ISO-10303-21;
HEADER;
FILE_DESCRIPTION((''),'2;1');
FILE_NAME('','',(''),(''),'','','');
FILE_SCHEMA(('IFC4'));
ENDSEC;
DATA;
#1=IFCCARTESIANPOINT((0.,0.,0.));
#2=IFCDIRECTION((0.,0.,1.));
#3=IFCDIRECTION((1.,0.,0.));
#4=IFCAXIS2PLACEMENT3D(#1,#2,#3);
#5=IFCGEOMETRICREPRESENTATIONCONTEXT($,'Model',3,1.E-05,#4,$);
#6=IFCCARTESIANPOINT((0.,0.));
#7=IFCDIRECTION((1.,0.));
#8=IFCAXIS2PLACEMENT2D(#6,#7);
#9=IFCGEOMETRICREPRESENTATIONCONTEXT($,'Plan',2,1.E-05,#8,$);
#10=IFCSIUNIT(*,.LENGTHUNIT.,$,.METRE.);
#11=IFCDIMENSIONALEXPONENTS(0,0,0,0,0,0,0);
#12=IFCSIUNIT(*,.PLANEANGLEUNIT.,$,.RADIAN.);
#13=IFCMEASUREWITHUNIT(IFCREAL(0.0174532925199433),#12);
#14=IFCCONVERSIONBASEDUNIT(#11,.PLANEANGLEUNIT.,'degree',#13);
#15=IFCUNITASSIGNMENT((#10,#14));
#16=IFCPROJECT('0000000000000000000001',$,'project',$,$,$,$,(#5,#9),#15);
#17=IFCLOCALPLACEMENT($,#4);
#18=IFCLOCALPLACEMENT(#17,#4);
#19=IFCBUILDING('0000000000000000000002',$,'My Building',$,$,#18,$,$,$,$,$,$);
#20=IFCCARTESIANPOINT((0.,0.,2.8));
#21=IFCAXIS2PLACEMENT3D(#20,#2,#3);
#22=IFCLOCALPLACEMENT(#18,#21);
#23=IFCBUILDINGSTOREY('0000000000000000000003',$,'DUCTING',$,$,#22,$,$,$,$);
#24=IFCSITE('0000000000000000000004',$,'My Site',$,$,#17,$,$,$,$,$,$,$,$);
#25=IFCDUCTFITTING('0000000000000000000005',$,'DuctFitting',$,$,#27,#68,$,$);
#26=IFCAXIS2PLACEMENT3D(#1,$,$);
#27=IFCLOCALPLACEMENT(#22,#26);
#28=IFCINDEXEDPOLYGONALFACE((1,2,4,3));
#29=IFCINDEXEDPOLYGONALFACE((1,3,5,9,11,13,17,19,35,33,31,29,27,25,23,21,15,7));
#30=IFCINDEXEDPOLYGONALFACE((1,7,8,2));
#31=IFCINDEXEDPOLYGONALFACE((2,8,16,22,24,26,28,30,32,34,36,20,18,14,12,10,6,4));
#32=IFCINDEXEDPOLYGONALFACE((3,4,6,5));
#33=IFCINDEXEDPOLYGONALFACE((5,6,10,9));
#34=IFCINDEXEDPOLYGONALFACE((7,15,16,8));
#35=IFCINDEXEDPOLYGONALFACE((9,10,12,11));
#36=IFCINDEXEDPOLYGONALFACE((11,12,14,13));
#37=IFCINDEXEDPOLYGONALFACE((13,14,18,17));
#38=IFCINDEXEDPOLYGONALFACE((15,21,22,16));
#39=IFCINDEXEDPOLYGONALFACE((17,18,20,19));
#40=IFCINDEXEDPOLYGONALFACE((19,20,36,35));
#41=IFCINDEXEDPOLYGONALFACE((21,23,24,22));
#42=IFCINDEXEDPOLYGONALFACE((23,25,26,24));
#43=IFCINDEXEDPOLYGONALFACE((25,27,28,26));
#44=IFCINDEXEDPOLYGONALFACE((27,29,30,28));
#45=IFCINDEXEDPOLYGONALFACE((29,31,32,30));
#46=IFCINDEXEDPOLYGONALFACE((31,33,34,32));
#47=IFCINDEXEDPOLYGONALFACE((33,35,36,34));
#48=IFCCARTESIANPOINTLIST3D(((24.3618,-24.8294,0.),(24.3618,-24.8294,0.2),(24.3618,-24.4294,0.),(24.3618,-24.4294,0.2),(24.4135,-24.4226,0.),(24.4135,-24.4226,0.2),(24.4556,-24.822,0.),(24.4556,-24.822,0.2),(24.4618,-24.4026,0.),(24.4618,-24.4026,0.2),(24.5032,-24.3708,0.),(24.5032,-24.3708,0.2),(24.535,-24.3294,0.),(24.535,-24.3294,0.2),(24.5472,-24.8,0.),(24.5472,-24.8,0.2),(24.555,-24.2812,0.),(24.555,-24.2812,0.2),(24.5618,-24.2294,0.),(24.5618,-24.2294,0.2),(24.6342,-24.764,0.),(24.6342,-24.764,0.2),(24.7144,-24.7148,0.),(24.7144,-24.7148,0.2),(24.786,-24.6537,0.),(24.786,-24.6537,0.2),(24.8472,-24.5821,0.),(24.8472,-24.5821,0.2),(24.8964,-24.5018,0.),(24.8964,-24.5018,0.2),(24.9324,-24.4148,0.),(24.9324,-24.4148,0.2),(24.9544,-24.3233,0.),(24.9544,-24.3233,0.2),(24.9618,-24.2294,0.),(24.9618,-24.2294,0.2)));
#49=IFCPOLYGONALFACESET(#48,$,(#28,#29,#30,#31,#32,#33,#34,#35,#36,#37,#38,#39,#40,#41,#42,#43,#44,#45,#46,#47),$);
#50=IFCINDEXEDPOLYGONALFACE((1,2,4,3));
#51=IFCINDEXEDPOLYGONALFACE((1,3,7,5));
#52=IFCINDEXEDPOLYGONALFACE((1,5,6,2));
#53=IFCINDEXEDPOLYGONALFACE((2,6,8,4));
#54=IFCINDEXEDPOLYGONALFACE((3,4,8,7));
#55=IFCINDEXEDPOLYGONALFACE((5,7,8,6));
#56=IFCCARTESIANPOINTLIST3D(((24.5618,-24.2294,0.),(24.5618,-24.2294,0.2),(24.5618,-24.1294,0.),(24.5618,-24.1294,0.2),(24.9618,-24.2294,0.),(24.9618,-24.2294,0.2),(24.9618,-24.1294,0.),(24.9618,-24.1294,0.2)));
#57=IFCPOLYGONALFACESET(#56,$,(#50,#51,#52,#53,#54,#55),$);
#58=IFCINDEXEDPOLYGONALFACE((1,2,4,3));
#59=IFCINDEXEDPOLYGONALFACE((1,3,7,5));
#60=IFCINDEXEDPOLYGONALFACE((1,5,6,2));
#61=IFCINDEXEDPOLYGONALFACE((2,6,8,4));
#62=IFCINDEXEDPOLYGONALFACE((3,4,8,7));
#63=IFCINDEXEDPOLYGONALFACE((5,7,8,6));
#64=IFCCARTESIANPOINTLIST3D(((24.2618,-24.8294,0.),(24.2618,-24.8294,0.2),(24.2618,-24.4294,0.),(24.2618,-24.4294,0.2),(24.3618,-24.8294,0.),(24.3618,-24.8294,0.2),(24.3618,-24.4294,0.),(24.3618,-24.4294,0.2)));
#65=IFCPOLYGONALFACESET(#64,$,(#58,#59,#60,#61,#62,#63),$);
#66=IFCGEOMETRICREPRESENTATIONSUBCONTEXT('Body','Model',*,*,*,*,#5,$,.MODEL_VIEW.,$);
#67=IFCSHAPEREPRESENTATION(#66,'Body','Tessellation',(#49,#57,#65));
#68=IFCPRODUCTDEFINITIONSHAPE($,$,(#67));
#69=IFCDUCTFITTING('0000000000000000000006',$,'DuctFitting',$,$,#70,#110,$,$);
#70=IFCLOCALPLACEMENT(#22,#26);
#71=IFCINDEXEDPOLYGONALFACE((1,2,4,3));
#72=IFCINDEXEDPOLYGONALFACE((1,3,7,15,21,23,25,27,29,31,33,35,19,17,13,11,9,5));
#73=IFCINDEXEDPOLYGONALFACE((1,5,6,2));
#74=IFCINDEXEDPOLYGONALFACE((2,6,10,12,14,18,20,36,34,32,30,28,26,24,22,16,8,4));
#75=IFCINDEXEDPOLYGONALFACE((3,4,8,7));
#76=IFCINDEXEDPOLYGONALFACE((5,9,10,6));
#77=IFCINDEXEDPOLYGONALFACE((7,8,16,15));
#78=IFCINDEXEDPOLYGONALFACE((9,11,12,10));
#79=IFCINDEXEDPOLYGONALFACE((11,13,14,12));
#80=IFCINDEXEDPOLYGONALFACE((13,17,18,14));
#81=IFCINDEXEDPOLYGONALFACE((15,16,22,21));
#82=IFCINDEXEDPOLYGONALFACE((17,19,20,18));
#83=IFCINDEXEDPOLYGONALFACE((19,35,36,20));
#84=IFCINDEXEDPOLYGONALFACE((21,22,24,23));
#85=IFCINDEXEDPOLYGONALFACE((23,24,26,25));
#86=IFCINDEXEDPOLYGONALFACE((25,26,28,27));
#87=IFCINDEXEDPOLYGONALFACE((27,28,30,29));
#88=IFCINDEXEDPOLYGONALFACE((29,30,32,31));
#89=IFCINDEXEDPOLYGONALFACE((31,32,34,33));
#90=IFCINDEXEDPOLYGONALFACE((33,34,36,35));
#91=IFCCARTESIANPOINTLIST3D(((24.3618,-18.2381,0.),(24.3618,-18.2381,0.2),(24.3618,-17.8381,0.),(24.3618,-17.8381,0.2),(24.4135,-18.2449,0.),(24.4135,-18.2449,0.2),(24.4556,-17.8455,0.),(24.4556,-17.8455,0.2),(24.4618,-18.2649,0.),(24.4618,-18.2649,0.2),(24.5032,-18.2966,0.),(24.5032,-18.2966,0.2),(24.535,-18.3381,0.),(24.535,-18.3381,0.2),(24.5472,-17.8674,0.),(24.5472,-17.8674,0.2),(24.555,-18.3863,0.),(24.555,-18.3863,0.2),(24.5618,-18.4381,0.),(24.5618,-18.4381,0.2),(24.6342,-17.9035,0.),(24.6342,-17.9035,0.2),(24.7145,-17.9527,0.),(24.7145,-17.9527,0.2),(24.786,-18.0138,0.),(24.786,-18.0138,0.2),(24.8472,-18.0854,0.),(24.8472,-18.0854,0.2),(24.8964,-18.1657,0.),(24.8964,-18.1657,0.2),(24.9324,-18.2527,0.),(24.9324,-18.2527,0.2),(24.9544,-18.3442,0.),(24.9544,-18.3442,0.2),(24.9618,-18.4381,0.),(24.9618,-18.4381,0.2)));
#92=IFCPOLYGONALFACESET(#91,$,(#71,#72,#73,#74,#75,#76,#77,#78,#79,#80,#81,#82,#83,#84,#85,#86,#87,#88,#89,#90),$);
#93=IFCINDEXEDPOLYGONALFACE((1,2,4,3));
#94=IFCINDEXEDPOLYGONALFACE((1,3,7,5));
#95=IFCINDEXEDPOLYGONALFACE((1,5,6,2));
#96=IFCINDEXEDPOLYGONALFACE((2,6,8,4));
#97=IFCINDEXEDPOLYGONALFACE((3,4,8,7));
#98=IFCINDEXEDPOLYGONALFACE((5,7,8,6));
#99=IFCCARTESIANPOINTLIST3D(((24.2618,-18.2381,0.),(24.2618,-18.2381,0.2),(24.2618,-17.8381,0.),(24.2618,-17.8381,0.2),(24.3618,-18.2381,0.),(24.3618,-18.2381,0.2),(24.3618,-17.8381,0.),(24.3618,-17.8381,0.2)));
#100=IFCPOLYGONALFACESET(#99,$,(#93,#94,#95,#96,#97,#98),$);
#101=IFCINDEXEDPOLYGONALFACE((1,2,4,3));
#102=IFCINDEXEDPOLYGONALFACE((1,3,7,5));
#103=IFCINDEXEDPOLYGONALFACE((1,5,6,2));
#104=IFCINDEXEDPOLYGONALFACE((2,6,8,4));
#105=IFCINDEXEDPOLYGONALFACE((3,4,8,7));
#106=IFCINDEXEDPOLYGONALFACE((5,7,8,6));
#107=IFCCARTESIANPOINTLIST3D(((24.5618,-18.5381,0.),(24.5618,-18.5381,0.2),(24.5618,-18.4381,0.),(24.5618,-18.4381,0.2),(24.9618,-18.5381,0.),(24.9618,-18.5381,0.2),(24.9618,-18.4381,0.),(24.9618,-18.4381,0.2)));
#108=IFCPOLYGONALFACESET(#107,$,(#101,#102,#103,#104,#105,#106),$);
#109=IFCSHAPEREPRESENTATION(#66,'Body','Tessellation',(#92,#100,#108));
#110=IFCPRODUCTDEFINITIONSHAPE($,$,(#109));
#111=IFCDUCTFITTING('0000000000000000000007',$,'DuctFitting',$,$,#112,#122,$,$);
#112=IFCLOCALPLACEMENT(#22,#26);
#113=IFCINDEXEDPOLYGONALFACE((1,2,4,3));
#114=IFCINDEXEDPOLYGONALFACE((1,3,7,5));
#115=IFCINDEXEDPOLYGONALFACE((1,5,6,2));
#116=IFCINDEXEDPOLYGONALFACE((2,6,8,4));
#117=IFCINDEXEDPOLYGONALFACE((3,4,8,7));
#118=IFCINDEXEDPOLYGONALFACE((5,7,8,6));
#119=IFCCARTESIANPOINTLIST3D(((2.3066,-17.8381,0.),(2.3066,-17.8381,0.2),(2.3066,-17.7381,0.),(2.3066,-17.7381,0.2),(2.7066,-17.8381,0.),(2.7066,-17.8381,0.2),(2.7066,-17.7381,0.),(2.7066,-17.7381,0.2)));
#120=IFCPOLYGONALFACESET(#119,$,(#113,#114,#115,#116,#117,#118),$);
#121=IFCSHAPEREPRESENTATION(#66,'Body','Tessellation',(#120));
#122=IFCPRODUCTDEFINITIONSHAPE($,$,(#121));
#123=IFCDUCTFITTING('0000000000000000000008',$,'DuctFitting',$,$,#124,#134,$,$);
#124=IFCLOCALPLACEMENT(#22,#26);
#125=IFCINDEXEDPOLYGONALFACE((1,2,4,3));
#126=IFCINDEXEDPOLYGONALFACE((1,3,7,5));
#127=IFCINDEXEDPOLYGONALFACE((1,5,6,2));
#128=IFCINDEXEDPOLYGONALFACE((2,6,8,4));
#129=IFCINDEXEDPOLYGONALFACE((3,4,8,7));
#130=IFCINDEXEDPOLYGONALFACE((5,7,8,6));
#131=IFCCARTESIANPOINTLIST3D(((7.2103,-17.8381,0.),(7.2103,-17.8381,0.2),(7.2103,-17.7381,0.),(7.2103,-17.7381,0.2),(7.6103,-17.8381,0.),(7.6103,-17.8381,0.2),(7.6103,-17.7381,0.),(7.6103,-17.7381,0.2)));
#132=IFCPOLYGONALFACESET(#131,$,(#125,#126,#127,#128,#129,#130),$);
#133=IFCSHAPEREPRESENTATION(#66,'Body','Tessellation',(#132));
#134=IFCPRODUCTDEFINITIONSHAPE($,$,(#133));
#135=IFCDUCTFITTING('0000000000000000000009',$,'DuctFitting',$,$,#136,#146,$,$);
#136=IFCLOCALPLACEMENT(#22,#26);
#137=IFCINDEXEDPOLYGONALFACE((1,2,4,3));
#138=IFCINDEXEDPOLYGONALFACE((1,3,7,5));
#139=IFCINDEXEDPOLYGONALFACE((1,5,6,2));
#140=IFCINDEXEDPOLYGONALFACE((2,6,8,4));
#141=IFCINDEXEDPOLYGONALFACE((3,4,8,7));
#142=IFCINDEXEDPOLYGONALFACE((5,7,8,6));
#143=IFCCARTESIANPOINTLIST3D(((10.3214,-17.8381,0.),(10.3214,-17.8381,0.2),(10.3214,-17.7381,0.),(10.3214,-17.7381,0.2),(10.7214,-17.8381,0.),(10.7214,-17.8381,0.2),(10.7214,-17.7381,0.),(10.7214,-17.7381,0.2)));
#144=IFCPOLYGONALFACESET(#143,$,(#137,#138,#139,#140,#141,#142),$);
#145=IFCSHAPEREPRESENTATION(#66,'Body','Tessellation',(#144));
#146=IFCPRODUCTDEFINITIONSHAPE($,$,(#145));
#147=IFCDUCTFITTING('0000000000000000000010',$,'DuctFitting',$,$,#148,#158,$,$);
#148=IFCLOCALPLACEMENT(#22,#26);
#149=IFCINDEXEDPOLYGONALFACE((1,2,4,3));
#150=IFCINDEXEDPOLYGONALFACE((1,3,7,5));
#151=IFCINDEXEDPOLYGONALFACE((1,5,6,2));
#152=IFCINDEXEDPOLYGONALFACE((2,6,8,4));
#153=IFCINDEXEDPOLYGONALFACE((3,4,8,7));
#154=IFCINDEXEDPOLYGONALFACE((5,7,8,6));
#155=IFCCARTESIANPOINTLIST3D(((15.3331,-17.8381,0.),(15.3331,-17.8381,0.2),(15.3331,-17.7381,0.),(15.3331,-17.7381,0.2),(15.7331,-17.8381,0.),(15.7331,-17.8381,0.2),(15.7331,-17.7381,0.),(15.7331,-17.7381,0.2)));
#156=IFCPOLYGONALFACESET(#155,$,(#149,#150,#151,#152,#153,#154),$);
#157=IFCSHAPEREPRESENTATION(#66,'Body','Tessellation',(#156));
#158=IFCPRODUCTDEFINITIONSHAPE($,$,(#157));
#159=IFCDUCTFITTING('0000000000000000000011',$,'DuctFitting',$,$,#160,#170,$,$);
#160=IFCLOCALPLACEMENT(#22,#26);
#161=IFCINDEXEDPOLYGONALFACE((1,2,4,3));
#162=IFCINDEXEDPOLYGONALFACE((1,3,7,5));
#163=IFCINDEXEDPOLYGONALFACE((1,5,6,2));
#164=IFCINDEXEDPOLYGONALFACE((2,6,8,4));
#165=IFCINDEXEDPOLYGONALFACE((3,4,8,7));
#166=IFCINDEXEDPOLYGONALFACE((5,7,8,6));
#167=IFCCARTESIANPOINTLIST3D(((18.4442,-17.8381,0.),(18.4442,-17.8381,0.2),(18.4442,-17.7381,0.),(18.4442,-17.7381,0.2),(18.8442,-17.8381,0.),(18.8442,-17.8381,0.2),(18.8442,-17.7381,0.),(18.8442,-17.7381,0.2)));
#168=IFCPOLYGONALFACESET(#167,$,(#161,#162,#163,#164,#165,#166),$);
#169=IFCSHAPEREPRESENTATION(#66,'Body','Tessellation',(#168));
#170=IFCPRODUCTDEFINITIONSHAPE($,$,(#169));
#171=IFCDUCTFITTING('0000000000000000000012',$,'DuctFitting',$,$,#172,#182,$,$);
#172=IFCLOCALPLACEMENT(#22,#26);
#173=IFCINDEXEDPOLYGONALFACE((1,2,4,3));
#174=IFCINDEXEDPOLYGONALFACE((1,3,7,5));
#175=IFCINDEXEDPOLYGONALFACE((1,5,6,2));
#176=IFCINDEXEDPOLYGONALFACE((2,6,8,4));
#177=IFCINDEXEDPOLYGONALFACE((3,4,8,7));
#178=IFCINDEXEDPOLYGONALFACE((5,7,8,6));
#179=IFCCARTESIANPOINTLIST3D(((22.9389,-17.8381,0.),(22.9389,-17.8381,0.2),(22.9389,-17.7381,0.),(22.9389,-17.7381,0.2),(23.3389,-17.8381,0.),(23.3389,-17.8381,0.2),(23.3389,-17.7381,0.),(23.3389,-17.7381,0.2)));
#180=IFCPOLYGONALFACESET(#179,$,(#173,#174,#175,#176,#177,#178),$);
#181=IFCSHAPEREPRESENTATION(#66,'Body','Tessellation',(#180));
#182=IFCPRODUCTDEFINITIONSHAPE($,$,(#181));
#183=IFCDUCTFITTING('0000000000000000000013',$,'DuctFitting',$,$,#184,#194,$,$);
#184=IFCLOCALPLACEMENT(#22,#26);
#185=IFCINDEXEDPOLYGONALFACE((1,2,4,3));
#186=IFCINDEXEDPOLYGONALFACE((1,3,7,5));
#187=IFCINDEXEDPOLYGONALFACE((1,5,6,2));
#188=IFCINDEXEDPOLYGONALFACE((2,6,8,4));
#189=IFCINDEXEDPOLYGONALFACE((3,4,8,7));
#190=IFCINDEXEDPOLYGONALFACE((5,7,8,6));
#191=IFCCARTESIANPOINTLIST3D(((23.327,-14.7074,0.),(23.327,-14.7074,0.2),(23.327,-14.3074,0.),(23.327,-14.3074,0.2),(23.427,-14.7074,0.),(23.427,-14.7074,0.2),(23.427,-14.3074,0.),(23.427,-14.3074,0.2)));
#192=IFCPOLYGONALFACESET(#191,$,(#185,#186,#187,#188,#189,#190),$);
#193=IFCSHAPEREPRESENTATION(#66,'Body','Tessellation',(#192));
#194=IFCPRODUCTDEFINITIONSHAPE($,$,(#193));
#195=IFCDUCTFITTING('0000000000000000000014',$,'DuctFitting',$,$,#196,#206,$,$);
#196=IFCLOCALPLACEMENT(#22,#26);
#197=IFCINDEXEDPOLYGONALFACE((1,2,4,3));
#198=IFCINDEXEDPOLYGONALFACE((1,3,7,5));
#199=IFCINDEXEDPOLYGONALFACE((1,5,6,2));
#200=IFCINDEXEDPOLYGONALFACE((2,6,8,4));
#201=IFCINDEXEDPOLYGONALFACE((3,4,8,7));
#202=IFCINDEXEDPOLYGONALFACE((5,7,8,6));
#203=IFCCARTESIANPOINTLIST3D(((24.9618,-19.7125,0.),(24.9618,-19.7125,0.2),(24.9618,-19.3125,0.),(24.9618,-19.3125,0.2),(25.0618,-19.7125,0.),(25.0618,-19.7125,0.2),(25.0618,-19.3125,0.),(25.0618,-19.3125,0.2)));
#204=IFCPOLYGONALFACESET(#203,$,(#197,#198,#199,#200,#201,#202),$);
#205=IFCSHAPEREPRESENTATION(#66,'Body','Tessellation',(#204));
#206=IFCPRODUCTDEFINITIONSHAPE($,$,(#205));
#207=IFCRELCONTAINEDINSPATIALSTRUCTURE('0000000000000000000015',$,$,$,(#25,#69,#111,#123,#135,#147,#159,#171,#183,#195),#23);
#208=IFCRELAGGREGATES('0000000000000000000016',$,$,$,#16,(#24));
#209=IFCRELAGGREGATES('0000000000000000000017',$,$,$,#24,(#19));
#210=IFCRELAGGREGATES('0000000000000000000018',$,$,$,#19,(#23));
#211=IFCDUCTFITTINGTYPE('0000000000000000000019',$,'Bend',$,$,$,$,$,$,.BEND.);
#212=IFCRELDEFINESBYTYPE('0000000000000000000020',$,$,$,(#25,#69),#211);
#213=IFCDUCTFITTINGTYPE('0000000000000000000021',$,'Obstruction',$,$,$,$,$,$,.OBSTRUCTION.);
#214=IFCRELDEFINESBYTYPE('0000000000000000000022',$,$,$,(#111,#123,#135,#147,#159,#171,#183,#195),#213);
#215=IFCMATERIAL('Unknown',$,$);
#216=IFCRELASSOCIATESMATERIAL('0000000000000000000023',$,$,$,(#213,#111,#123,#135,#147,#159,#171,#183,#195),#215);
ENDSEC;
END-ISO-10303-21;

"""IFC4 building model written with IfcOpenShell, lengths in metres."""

from ifc_helpers import new_model, entity, si_unit, converted_unit, frame, origin_with_axes, origin_2d_with_axis, place, context, subcontext, project, spatial, line, arc, indexed_curve, rectangle, outline, extrude, source, transform, mapped, material, material_profile, profile_set, profile_usage, type_object, type_shapes, element, save


model = new_model("IFC4")

# Units and contexts
model_context = context("Model", 3, precision=1e-05, world=origin_with_axes())
plan_context = context("Plan", 2, precision=1e-05, world=origin_2d_with_axis())
body_context = subcontext(model_context, "Body", "Model", "MODEL_VIEW")
ifc_project = project(units=[si_unit("LENGTHUNIT", "METRE"), converted_unit("PLANEANGLEUNIT", "degree", entity("IfcReal", 0.0174532925199433), si_unit("PLANEANGLEUNIT", "RADIAN"), dimensions=[0, 0, 0, 0, 0, 0, 0])], contexts=[model_context, plan_context])

# Site, building, storey
site_placement = place(None, origin_with_axes())
site = spatial("IfcSite", under=ifc_project, at=site_placement, Name="My Site")
building_placement = place(site_placement, origin_with_axes())
building = spatial("IfcBuilding", under=site, at=building_placement, Name="My Building")
storey_placement = place(building_placement, frame((0.0, 0.0, 2.8), z_axis=(0.0, 0.0, 1.0), x_axis=(1.0, 0.0, 0.0)))
storey = spatial("IfcBuildingStorey", under=building, at=storey_placement, Name="DUCTING")

# Shared definitions
ifc_material = material(Name="Unknown")

# Duct fittings
duct_fitting_type_1 = type_object("IfcDuctFittingType", Name="Bend", PredefinedType="BEND")
shared_shape = source(origin_with_axes(), body_context, "Body", "SweptSolid", [
    extrude(outline(indexed_curve([(-0.2, 0.0), (-0.2586, -0.1414), (-0.4, -0.2), (-0.4, -0.6), (0.0243, -0.4243), (0.2, 0.0)], segments=[arc(1, 2, 3), line(3, 4), arc(4, 5, 6), line(6, 1)])), frame((0.0, -0.1, -0.1), z_axis=(0.0, -1.0, 0.0), x_axis=(1.0, 0.0, 0.0)), (0.0, 0.0, -1.0), 0.2),
    extrude(rectangle(XDim=0.4, YDim=0.2), origin_with_axes(), (0.0, 0.0, -1.0), 0.1),
    extrude(rectangle(XDim=0.4, YDim=0.2), frame((-0.4, 0.0, -0.5), z_axis=(-1.0, 0.0, 0.0), x_axis=(0.0, 0.0, -1.0)), (0.0, 0.0, 1.0), 0.1),
])
type_shapes(duct_fitting_type_1, [shared_shape])
for number, where, z_axis, x_axis, name in (
    (1, (24.7618, -24.1294, 0.1), (0.0, 1.0, 0.0), (1.0, 0.0, 0.0), "DuctFitting"),
    (2, (24.2618, -18.0381, 0.1), (-1.0, 0.0, 0.0), (0.0, 1.0, 0.0), "DuctFitting"),
):
    element("IfcDuctFitting", number, at=place(storey_placement, frame(where, z_axis=z_axis, x_axis=x_axis)), inside=storey, type_object=duct_fitting_type_1, Name=name, context=body_context, shape_type="MappedRepresentation", body=[
        mapped(shared_shape, transform((0.0, 0.0, 0.0), x_axis=(1.0, 0.0, 0.0), y_axis=(0.0, 1.0, 0.0), z_axis=(0.0, 0.0, 1.0), scale=1.0)),
    ])
ifc_material_profile_1 = material_profile(ifc_material, rectangle(XDim=0.4, YDim=0.2))
ifc_profile_set_1 = profile_set([ifc_material_profile_1])
ifc_profile_usage_1 = profile_usage(ifc_profile_set_1, cardinal=5)
duct_fitting_type_2 = type_object("IfcDuctFittingType", Name="Obstruction", PredefinedType="OBSTRUCTION", material=ifc_profile_set_1)
duct_fitting_1_placement = place(storey_placement, frame((2.5066, -17.7381, 0.1), z_axis=(0.0, -1.0, 0.0), x_axis=(-1.0, 0.0, 0.0)))
element("IfcDuctFitting", 3, at=duct_fitting_1_placement, inside=storey, type_object=duct_fitting_type_2, material=ifc_profile_usage_1, Name="DuctFitting", context=body_context, shape_type="SweptSolid", body=[
    extrude(rectangle(XDim=0.4, YDim=0.2), origin_with_axes(), (0.0, 0.0, 1.0), 0.1),
])
ifc_profile_usage_2 = profile_usage(ifc_profile_set_1, cardinal=5)
duct_fitting_2_placement = place(storey_placement, frame((7.4103, -17.7381, 0.1), z_axis=(0.0, -1.0, 0.0), x_axis=(1.0, 0.0, 0.0)))
element("IfcDuctFitting", 4, at=duct_fitting_2_placement, inside=storey, type_object=duct_fitting_type_2, material=ifc_profile_usage_2, Name="DuctFitting", context=body_context, shape_type="SweptSolid", body=[
    extrude(rectangle(XDim=0.4, YDim=0.2), origin_with_axes(), (0.0, 0.0, 1.0), 0.1),
])
ifc_profile_usage_3 = profile_usage(ifc_profile_set_1, cardinal=5)
duct_fitting_3_placement = place(storey_placement, frame((10.5214, -17.8381, 0.1), z_axis=(0.000001, 1.0, 0.0), x_axis=(-1.0, 0.000001, 0.0)))
element("IfcDuctFitting", 5, at=duct_fitting_3_placement, inside=storey, type_object=duct_fitting_type_2, material=ifc_profile_usage_3, Name="DuctFitting", context=body_context, shape_type="SweptSolid", body=[
    extrude(rectangle(XDim=0.4, YDim=0.2), origin_with_axes(), (0.0, 0.0, 1.0), 0.1),
])
ifc_profile_usage_4 = profile_usage(ifc_profile_set_1, cardinal=5)
duct_fitting_4_placement = place(storey_placement, frame((15.5331, -17.7381, 0.1), z_axis=(0.0, -1.0, 0.0), x_axis=(1.0, 0.0, 0.0)))
element("IfcDuctFitting", 6, at=duct_fitting_4_placement, inside=storey, type_object=duct_fitting_type_2, material=ifc_profile_usage_4, Name="DuctFitting", context=body_context, shape_type="SweptSolid", body=[
    extrude(rectangle(XDim=0.4, YDim=0.2), origin_with_axes(), (0.0, 0.0, 1.0), 0.1),
])
ifc_profile_usage_5 = profile_usage(ifc_profile_set_1, cardinal=5)
duct_fitting_5_placement = place(storey_placement, frame((18.6442, -17.7381, 0.1), z_axis=(0.0, -1.0, 0.0), x_axis=(1.0, 0.0, 0.0)))
element("IfcDuctFitting", 7, at=duct_fitting_5_placement, inside=storey, type_object=duct_fitting_type_2, material=ifc_profile_usage_5, Name="DuctFitting", context=body_context, shape_type="SweptSolid", body=[
    extrude(rectangle(XDim=0.4, YDim=0.2), origin_with_axes(), (0.0, 0.0, 1.0), 0.1),
])
ifc_profile_usage_6 = profile_usage(ifc_profile_set_1, cardinal=5)
duct_fitting_6_placement = place(storey_placement, frame((23.1389, -17.7381, 0.1), z_axis=(0.0, -1.0, 0.0), x_axis=(1.0, 0.0, 0.0)))
element("IfcDuctFitting", 8, at=duct_fitting_6_placement, inside=storey, type_object=duct_fitting_type_2, material=ifc_profile_usage_6, Name="DuctFitting", context=body_context, shape_type="SweptSolid", body=[
    extrude(rectangle(XDim=0.4, YDim=0.2), origin_with_axes(), (0.0, 0.0, 1.0), 0.1),
])
ifc_profile_usage_7 = profile_usage(ifc_profile_set_1, cardinal=5)
duct_fitting_7_placement = place(storey_placement, frame((23.327, -14.5074, 0.1), z_axis=(1.0, 0.0, 0.0), x_axis=(0.0, 1.0, 0.0)))
element("IfcDuctFitting", 9, at=duct_fitting_7_placement, inside=storey, type_object=duct_fitting_type_2, material=ifc_profile_usage_7, Name="DuctFitting", context=body_context, shape_type="SweptSolid", body=[
    extrude(rectangle(XDim=0.4, YDim=0.2), origin_with_axes(), (0.0, 0.0, 1.0), 0.1),
])
ifc_profile_usage_8 = profile_usage(ifc_profile_set_1, cardinal=5)
duct_fitting_8_placement = place(storey_placement, frame((24.9618, -19.5125, 0.1), z_axis=(1.0, 0.0, 0.0), x_axis=(0.0, 1.0, 0.0)))
element("IfcDuctFitting", 10, at=duct_fitting_8_placement, inside=storey, type_object=duct_fitting_type_2, material=ifc_profile_usage_8, Name="DuctFitting", context=body_context, shape_type="SweptSolid", body=[
    extrude(rectangle(XDim=0.4, YDim=0.2), origin_with_axes(), (0.0, 0.0, 1.0), 0.1),
])

save(model, "model.ifc")
